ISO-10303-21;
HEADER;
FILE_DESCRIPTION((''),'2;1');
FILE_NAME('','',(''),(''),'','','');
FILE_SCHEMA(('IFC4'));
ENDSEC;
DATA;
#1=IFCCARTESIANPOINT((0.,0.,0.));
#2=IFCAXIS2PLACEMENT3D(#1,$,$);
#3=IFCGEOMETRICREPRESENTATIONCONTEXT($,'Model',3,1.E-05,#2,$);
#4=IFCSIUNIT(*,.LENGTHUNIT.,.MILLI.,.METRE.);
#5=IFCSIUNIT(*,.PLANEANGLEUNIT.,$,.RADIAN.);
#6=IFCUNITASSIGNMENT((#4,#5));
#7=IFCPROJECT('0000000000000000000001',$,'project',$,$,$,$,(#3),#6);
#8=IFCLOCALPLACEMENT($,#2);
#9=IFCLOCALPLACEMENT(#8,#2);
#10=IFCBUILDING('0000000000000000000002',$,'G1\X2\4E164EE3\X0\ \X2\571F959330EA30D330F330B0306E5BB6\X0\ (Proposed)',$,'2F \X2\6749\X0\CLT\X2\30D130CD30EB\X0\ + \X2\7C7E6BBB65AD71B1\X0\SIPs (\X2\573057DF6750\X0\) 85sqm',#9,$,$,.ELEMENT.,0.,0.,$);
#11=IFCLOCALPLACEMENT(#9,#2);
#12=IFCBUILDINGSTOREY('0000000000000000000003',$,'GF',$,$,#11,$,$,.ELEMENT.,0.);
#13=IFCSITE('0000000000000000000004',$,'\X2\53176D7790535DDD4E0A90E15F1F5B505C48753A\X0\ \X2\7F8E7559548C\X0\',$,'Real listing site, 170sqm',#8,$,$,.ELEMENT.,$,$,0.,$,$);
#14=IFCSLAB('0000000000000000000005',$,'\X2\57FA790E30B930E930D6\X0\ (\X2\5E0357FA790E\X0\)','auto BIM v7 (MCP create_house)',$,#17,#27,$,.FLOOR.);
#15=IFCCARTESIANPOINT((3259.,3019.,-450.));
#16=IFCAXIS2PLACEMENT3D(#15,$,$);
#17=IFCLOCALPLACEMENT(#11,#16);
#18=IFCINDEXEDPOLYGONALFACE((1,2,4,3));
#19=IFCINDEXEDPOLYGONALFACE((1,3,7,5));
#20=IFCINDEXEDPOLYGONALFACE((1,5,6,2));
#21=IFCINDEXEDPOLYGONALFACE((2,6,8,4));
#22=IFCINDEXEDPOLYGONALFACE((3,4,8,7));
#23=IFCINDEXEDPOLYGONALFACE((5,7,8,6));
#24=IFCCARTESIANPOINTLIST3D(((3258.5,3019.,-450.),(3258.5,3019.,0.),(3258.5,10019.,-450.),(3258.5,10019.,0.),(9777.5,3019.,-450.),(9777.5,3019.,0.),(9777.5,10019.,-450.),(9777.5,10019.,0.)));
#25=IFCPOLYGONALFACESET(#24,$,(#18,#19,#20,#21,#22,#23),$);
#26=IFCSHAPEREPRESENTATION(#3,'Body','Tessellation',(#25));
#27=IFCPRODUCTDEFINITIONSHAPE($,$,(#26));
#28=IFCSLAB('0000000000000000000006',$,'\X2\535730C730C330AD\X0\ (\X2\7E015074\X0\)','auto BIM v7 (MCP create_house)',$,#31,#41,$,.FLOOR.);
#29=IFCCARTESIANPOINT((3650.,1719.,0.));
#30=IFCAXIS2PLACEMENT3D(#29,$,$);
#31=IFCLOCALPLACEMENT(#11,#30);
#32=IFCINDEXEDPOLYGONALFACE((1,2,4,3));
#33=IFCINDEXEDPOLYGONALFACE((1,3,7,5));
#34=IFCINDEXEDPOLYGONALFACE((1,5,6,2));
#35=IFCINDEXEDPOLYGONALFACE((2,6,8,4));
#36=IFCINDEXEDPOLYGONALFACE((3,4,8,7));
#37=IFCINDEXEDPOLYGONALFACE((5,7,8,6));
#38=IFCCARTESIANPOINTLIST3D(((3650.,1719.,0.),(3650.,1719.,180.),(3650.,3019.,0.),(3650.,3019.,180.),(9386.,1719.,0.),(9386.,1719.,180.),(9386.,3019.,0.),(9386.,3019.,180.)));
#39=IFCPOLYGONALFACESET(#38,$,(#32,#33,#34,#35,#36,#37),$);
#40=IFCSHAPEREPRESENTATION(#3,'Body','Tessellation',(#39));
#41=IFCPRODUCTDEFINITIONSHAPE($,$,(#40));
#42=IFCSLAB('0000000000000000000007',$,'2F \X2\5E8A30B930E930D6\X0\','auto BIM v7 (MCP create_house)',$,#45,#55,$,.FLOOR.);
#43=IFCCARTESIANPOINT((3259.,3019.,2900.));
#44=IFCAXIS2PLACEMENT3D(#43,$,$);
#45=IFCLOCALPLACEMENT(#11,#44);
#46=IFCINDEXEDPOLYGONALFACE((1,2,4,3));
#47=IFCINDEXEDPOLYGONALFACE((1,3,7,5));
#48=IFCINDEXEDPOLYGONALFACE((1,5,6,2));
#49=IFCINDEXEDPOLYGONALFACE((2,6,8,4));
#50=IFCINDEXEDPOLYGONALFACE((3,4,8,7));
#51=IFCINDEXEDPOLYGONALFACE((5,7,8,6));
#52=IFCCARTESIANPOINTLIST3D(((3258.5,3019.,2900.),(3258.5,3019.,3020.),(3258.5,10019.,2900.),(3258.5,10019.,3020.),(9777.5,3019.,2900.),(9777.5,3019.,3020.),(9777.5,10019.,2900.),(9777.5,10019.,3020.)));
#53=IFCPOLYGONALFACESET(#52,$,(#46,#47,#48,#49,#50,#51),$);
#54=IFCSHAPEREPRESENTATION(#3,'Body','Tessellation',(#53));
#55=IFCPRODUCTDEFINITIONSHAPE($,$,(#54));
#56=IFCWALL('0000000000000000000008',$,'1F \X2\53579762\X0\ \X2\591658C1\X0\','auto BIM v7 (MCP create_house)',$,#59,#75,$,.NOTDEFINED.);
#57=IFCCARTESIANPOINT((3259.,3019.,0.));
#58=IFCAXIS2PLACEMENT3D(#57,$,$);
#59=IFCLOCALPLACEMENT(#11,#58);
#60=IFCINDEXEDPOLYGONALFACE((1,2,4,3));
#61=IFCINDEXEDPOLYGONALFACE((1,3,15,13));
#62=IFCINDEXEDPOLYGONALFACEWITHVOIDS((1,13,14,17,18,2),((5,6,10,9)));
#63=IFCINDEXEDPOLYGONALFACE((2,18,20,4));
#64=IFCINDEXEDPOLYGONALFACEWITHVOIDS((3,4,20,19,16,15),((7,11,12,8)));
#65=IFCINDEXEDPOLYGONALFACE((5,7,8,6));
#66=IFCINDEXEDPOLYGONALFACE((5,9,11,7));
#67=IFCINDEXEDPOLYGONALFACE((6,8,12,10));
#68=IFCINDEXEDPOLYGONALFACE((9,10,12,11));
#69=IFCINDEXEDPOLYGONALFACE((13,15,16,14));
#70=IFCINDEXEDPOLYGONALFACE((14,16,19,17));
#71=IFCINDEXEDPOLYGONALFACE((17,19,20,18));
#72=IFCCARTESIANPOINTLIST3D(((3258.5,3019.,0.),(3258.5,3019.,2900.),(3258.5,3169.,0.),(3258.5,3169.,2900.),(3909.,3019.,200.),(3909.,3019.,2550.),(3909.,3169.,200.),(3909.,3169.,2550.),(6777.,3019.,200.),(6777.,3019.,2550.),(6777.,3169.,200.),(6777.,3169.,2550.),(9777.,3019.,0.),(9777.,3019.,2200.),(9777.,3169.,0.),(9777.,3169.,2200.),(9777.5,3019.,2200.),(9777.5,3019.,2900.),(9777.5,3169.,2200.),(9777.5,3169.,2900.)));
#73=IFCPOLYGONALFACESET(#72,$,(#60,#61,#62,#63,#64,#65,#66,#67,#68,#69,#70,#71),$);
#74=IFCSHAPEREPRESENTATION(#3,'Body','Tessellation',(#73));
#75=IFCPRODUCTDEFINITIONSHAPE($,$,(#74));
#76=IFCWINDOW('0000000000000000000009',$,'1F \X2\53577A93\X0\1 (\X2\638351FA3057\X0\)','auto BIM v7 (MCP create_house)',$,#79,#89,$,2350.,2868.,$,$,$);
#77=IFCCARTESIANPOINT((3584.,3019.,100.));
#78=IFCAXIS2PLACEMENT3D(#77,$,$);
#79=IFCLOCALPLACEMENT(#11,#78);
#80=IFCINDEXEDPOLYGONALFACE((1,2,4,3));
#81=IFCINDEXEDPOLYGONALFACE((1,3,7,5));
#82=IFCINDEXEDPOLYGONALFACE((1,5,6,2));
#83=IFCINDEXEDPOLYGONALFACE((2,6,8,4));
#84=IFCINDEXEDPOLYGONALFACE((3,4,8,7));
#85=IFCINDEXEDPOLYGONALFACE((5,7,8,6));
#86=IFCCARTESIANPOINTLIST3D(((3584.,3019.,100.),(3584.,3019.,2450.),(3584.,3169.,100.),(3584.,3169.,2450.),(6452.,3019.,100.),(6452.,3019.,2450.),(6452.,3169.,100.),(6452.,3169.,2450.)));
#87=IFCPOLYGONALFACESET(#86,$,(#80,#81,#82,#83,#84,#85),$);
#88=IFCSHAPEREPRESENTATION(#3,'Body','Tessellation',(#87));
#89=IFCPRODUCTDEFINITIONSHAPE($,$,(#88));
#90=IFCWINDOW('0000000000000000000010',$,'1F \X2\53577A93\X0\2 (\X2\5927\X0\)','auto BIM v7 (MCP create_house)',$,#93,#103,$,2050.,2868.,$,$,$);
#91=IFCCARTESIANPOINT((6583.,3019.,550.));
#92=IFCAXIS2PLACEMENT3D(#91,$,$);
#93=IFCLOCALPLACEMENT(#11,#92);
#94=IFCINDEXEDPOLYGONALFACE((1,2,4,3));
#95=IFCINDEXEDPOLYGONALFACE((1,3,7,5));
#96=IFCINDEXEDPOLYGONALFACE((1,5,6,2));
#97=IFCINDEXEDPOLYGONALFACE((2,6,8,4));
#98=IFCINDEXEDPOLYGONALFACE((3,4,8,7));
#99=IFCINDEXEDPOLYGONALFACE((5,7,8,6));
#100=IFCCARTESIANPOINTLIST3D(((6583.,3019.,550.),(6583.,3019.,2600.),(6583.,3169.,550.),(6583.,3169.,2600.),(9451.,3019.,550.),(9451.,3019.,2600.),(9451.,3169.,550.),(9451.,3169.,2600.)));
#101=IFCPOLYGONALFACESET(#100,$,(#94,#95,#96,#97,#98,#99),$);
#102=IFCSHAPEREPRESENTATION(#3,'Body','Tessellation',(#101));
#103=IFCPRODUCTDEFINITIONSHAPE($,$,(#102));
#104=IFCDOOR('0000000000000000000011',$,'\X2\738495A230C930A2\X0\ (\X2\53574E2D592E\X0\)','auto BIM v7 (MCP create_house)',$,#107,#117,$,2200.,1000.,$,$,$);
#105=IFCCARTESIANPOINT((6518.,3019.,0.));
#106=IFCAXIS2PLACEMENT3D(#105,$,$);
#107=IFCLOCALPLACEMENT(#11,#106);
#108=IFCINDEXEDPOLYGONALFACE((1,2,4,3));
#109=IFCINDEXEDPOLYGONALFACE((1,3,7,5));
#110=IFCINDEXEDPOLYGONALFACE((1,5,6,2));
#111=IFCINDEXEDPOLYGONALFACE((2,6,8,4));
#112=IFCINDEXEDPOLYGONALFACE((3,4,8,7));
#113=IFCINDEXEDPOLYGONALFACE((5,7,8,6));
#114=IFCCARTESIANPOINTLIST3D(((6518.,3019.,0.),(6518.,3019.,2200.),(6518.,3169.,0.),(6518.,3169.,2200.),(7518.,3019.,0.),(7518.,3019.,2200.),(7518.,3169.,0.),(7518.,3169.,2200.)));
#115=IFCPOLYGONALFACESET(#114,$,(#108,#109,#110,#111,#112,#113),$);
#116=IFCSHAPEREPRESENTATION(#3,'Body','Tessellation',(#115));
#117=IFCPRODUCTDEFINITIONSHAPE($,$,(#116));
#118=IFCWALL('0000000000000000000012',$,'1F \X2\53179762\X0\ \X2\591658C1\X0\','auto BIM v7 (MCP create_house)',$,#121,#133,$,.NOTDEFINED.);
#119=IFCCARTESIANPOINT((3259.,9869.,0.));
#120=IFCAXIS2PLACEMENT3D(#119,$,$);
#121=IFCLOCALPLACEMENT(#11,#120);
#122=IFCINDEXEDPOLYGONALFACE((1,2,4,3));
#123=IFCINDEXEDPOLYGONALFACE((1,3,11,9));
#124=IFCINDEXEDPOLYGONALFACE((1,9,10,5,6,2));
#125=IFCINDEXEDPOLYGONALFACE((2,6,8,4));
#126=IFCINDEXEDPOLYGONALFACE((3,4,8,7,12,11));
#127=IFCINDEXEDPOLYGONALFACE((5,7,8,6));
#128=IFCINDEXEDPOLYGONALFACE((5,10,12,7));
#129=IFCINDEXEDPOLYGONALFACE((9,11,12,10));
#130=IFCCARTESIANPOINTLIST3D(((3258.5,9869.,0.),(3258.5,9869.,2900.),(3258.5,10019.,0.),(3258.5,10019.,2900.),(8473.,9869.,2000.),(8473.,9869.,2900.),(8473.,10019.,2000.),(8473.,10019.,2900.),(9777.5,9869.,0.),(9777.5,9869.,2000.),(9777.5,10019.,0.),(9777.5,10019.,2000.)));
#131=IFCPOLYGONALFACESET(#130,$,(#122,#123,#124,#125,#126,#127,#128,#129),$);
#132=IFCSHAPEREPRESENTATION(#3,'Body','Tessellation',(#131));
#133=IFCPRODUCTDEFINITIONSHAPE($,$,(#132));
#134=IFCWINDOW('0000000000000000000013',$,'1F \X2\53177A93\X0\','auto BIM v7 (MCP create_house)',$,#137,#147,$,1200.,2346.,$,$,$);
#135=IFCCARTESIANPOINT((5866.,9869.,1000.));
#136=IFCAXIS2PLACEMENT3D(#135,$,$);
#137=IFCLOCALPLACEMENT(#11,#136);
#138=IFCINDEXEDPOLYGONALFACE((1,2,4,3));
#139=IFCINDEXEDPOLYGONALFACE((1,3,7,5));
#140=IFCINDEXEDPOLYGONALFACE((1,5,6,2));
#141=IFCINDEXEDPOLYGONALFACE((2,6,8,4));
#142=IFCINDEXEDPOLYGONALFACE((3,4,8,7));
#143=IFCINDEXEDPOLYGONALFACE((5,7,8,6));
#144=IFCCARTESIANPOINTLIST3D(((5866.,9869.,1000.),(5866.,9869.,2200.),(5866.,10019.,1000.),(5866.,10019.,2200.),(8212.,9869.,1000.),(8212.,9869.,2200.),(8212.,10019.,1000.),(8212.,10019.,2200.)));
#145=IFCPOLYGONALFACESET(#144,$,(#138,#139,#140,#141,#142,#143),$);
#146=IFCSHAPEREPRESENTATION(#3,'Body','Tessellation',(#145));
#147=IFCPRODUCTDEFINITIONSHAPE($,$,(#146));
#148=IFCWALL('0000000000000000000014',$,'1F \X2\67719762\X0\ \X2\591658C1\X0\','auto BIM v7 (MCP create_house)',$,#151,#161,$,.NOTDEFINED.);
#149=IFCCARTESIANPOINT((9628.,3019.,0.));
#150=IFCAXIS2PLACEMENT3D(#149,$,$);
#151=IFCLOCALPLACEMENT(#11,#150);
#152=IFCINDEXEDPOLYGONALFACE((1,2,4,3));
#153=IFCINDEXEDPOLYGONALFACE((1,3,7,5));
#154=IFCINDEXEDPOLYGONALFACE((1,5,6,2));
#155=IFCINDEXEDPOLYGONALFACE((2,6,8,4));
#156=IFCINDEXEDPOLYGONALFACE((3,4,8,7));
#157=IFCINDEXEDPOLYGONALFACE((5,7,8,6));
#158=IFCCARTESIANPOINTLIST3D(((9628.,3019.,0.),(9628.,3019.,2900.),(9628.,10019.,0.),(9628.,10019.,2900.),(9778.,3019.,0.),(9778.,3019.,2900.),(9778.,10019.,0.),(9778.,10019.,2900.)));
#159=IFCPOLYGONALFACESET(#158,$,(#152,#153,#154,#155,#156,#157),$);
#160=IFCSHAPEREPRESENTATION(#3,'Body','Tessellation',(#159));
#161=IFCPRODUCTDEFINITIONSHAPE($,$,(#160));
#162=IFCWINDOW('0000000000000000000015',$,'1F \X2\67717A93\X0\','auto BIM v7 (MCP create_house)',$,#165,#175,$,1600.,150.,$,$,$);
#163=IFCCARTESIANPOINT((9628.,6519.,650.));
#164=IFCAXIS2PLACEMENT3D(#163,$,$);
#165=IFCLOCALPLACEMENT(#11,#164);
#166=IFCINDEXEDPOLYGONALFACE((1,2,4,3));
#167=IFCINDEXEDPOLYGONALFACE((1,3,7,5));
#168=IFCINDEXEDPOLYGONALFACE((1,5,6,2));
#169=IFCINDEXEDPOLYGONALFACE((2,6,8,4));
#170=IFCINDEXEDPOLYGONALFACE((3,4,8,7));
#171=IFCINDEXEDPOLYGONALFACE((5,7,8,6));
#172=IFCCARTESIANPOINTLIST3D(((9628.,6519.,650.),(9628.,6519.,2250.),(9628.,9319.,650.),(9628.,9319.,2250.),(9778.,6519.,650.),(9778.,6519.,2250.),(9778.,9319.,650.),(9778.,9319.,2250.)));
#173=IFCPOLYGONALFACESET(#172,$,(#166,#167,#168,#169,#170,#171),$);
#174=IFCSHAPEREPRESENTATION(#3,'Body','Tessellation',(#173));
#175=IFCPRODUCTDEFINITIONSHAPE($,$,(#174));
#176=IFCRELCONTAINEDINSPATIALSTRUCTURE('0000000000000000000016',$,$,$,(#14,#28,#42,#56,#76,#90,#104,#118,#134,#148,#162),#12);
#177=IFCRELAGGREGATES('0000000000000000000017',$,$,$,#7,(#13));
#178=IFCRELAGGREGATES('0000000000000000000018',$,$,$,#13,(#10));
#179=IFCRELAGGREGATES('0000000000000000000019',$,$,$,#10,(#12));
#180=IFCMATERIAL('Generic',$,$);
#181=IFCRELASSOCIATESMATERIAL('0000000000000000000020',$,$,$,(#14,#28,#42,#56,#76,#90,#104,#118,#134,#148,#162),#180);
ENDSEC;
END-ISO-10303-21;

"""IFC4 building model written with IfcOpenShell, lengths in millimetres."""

from ifc_helpers import new_model, si_unit, frame, frame_2d, origin, place, context, project, spatial, rectangle, extrude, material, element, fill, save


model = new_model("IFC4")

# Units and contexts
model_context = context("Model", 3, precision=1e-05, world=origin())
ifc_project = project(units=[si_unit("LENGTHUNIT", "METRE", prefix="MILLI"), si_unit("PLANEANGLEUNIT", "RADIAN")], contexts=[model_context])

# Site, building, storey
site_placement = place(None, origin())
site = spatial("IfcSite", under=ifc_project, at=site_placement, Name="北海道川上郡弟子屈町 美留和", ObjectType="Real listing site, 170sqm", CompositionType="ELEMENT", RefElevation=0.0)
building_placement = place(site_placement, origin())
building = spatial("IfcBuilding", under=site, at=building_placement, Name="G1世代 土間リビングの家 (Proposed)", ObjectType="2F 杉CLTパネル + 籾殻断熱SIPs (地域材) 85sqm", CompositionType="ELEMENT", ElevationOfRefHeight=0.0, ElevationOfTerrain=0.0)
storey_placement = place(building_placement, origin())
storey = spatial("IfcBuildingStorey", under=building, at=storey_placement, Name="GF", CompositionType="ELEMENT", Elevation=0.0)

# Slabs
ifc_material = material(Name="Generic")
slab_1_placement = place(storey_placement, frame((3259.0, 3019.0, -450.0)))
element("IfcSlab", 1, at=slab_1_placement, inside=storey, material=ifc_material, Name="基礎スラブ (布基礎)", Description="auto BIM v7 (MCP create_house)", PredefinedType="FLOOR", context=model_context, shape_type="SweptSolid", body=[
    extrude(rectangle(XDim=6519.0, YDim=7000.0, at=frame_2d((3259.0, 3500.0))), frame((3259.0, 3019.0, -450.0)), (0.0, 0.0, 1.0), 450.0),
])
slab_2_placement = place(storey_placement, frame((3650.0, 1719.0, 0.0)))
element("IfcSlab", 2, at=slab_2_placement, inside=storey, material=ifc_material, Name="南デッキ (縁側)", Description="auto BIM v7 (MCP create_house)", PredefinedType="FLOOR", context=model_context, shape_type="SweptSolid", body=[
    extrude(rectangle(XDim=5736.0, YDim=1300.0, at=frame_2d((2868.0, 650.0))), frame((3650.0, 1719.0, 0.0)), (0.0, 0.0, 1.0), 180.0),
])
slab_3_placement = place(storey_placement, frame((3259.0, 3019.0, 2900.0)))
element("IfcSlab", 3, at=slab_3_placement, inside=storey, material=ifc_material, Name="2F 床スラブ", Description="auto BIM v7 (MCP create_house)", PredefinedType="FLOOR", context=model_context, shape_type="SweptSolid", body=[
    extrude(rectangle(XDim=6519.0, YDim=7000.0, at=frame_2d((3259.0, 3500.0))), frame((3259.0, 3019.0, 2900.0)), (0.0, 0.0, 1.0), 120.0),
])

# Wall, openings, windows, door
wall_1_placement = place(storey_placement, frame((3259.0, 3019.0, 0.0)))
wall_1 = element("IfcWall", 4, at=wall_1_placement, inside=storey, material=ifc_material, Name="1F 南面 外壁", Description="auto BIM v7 (MCP create_house)", PredefinedType="NOTDEFINED", context=model_context, shape_type="SweptSolid", body=[
    extrude(rectangle(XDim=6519.0, YDim=150.0, at=frame_2d((3259.0, 75.0))), frame((3259.0, 3019.0, 0.0)), (0.0, 0.0, 1.0), 2900.0),
])
opening_1_placement = place(storey_placement, frame((3584.0, 3019.0, 100.0)))
opening_1 = element("IfcOpeningElement", 5, at=opening_1_placement, cuts=wall_1, PredefinedType="NOTDEFINED", context=model_context, shape_type="SweptSolid", body=[
    extrude(rectangle(XDim=2868.0, YDim=150.0, at=frame_2d((1434.0, 75.0))), frame((3584.0, 3019.0, 100.0)), (0.0, 0.0, 1.0), 2350.0),
])
opening_2_placement = place(storey_placement, frame((6583.0, 3019.0, 550.0)))
opening_2 = element("IfcOpeningElement", 6, at=opening_2_placement, cuts=wall_1, PredefinedType="NOTDEFINED", context=model_context, shape_type="SweptSolid", body=[
    extrude(rectangle(XDim=2868.0, YDim=150.0, at=frame_2d((1434.0, 75.0))), frame((6583.0, 3019.0, 550.0)), (0.0, 0.0, 1.0), 2050.0),
])
opening_3_placement = place(storey_placement, frame((6518.0, 3019.0, 0.0)))
opening_3 = element("IfcOpeningElement", 7, at=opening_3_placement, cuts=wall_1, PredefinedType="NOTDEFINED", context=model_context, shape_type="SweptSolid", body=[
    extrude(rectangle(XDim=1000.0, YDim=150.0, at=frame_2d((500.0, 75.0))), frame((6518.0, 3019.0, 0.0)), (0.0, 0.0, 1.0), 2200.0),
])
window_1_placement = place(storey_placement, frame((3584.0, 3019.0, 100.0)))
window_1 = element("IfcWindow", 8, at=window_1_placement, inside=storey, material=ifc_material, Name="1F 南窓1 (掃出し)", Description="auto BIM v7 (MCP create_house)", OverallHeight=2350.0, OverallWidth=2868.0, context=model_context, shape_type="SweptSolid", body=[
    extrude(rectangle(XDim=2868.0, YDim=150.0, at=frame_2d((1434.0, 75.0))), frame((3584.0, 3019.0, 100.0)), (0.0, 0.0, 1.0), 2350.0),
])
fill(opening_1, window_1)
window_2_placement = place(storey_placement, frame((6583.0, 3019.0, 550.0)))
window_2 = element("IfcWindow", 9, at=window_2_placement, inside=storey, material=ifc_material, Name="1F 南窓2 (大)", Description="auto BIM v7 (MCP create_house)", OverallHeight=2050.0, OverallWidth=2868.0, context=model_context, shape_type="SweptSolid", body=[
    extrude(rectangle(XDim=2868.0, YDim=150.0, at=frame_2d((1434.0, 75.0))), frame((6583.0, 3019.0, 550.0)), (0.0, 0.0, 1.0), 2050.0),
])
fill(opening_2, window_2)
door_placement = place(storey_placement, frame((6518.0, 3019.0, 0.0)))
door = element("IfcDoor", 10, at=door_placement, inside=storey, material=ifc_material, Name="玄関ドア (南中央)", Description="auto BIM v7 (MCP create_house)", OverallHeight=2200.0, OverallWidth=1000.0, context=model_context, shape_type="SweptSolid", body=[
    extrude(rectangle(XDim=1000.0, YDim=150.0, at=frame_2d((500.0, 75.0))), frame((6518.0, 3019.0, 0.0)), (0.0, 0.0, 1.0), 2200.0),
])
fill(opening_3, door)

# Walls, openings, windows
wall_2_placement = place(storey_placement, frame((3259.0, 9869.0, 0.0)))
wall_2 = element("IfcWall", 11, at=wall_2_placement, inside=storey, material=ifc_material, Name="1F 北面 外壁", Description="auto BIM v7 (MCP create_house)", PredefinedType="NOTDEFINED", context=model_context, shape_type="SweptSolid", body=[
    extrude(rectangle(XDim=6519.0, YDim=150.0, at=frame_2d((3259.0, 75.0))), frame((3259.0, 9869.0, 0.0)), (0.0, 0.0, 1.0), 2900.0),
])
opening_4_placement = place(storey_placement, frame((5866.0, 9869.0, 1000.0)))
opening_4 = element("IfcOpeningElement", 12, at=opening_4_placement, cuts=wall_2, PredefinedType="NOTDEFINED", context=model_context, shape_type="SweptSolid", body=[
    extrude(rectangle(XDim=2346.0, YDim=150.0, at=frame_2d((1173.0, 75.0))), frame((5866.0, 9869.0, 1000.0)), (0.0, 0.0, 1.0), 1200.0),
])
window_3_placement = place(storey_placement, frame((5866.0, 9869.0, 1000.0)))
window_3 = element("IfcWindow", 13, at=window_3_placement, inside=storey, material=ifc_material, Name="1F 北窓", Description="auto BIM v7 (MCP create_house)", OverallHeight=1200.0, OverallWidth=2346.0, context=model_context, shape_type="SweptSolid", body=[
    extrude(rectangle(XDim=2346.0, YDim=150.0, at=frame_2d((1173.0, 75.0))), frame((5866.0, 9869.0, 1000.0)), (0.0, 0.0, 1.0), 1200.0),
])
fill(opening_4, window_3)
wall_3_placement = place(storey_placement, frame((9628.0, 3019.0, 0.0)))
wall_3 = element("IfcWall", 14, at=wall_3_placement, inside=storey, material=ifc_material, Name="1F 東面 外壁", Description="auto BIM v7 (MCP create_house)", PredefinedType="NOTDEFINED", context=model_context, shape_type="SweptSolid", body=[
    extrude(rectangle(XDim=150.0, YDim=7000.0, at=frame_2d((75.0, 3500.0))), frame((9628.0, 3019.0, 0.0)), (0.0, 0.0, 1.0), 2900.0),
])
opening_5_placement = place(storey_placement, frame((9628.0, 6519.0, 650.0)))
opening_5 = element("IfcOpeningElement", 15, at=opening_5_placement, cuts=wall_3, PredefinedType="NOTDEFINED", context=model_context, shape_type="SweptSolid", body=[
    extrude(rectangle(XDim=150.0, YDim=2800.0, at=frame_2d((75.0, 1400.0))), frame((9628.0, 6519.0, 650.0)), (0.0, 0.0, 1.0), 1600.0),
])
window_4_placement = place(storey_placement, frame((9628.0, 6519.0, 650.0)))
window_4 = element("IfcWindow", 16, at=window_4_placement, inside=storey, material=ifc_material, Name="1F 東窓", Description="auto BIM v7 (MCP create_house)", OverallHeight=1600.0, OverallWidth=150.0, context=model_context, shape_type="SweptSolid", body=[
    extrude(rectangle(XDim=150.0, YDim=2800.0, at=frame_2d((75.0, 1400.0))), frame((9628.0, 6519.0, 650.0)), (0.0, 0.0, 1.0), 1600.0),
])
fill(opening_5, window_4)

save(model, "model.ifc")
